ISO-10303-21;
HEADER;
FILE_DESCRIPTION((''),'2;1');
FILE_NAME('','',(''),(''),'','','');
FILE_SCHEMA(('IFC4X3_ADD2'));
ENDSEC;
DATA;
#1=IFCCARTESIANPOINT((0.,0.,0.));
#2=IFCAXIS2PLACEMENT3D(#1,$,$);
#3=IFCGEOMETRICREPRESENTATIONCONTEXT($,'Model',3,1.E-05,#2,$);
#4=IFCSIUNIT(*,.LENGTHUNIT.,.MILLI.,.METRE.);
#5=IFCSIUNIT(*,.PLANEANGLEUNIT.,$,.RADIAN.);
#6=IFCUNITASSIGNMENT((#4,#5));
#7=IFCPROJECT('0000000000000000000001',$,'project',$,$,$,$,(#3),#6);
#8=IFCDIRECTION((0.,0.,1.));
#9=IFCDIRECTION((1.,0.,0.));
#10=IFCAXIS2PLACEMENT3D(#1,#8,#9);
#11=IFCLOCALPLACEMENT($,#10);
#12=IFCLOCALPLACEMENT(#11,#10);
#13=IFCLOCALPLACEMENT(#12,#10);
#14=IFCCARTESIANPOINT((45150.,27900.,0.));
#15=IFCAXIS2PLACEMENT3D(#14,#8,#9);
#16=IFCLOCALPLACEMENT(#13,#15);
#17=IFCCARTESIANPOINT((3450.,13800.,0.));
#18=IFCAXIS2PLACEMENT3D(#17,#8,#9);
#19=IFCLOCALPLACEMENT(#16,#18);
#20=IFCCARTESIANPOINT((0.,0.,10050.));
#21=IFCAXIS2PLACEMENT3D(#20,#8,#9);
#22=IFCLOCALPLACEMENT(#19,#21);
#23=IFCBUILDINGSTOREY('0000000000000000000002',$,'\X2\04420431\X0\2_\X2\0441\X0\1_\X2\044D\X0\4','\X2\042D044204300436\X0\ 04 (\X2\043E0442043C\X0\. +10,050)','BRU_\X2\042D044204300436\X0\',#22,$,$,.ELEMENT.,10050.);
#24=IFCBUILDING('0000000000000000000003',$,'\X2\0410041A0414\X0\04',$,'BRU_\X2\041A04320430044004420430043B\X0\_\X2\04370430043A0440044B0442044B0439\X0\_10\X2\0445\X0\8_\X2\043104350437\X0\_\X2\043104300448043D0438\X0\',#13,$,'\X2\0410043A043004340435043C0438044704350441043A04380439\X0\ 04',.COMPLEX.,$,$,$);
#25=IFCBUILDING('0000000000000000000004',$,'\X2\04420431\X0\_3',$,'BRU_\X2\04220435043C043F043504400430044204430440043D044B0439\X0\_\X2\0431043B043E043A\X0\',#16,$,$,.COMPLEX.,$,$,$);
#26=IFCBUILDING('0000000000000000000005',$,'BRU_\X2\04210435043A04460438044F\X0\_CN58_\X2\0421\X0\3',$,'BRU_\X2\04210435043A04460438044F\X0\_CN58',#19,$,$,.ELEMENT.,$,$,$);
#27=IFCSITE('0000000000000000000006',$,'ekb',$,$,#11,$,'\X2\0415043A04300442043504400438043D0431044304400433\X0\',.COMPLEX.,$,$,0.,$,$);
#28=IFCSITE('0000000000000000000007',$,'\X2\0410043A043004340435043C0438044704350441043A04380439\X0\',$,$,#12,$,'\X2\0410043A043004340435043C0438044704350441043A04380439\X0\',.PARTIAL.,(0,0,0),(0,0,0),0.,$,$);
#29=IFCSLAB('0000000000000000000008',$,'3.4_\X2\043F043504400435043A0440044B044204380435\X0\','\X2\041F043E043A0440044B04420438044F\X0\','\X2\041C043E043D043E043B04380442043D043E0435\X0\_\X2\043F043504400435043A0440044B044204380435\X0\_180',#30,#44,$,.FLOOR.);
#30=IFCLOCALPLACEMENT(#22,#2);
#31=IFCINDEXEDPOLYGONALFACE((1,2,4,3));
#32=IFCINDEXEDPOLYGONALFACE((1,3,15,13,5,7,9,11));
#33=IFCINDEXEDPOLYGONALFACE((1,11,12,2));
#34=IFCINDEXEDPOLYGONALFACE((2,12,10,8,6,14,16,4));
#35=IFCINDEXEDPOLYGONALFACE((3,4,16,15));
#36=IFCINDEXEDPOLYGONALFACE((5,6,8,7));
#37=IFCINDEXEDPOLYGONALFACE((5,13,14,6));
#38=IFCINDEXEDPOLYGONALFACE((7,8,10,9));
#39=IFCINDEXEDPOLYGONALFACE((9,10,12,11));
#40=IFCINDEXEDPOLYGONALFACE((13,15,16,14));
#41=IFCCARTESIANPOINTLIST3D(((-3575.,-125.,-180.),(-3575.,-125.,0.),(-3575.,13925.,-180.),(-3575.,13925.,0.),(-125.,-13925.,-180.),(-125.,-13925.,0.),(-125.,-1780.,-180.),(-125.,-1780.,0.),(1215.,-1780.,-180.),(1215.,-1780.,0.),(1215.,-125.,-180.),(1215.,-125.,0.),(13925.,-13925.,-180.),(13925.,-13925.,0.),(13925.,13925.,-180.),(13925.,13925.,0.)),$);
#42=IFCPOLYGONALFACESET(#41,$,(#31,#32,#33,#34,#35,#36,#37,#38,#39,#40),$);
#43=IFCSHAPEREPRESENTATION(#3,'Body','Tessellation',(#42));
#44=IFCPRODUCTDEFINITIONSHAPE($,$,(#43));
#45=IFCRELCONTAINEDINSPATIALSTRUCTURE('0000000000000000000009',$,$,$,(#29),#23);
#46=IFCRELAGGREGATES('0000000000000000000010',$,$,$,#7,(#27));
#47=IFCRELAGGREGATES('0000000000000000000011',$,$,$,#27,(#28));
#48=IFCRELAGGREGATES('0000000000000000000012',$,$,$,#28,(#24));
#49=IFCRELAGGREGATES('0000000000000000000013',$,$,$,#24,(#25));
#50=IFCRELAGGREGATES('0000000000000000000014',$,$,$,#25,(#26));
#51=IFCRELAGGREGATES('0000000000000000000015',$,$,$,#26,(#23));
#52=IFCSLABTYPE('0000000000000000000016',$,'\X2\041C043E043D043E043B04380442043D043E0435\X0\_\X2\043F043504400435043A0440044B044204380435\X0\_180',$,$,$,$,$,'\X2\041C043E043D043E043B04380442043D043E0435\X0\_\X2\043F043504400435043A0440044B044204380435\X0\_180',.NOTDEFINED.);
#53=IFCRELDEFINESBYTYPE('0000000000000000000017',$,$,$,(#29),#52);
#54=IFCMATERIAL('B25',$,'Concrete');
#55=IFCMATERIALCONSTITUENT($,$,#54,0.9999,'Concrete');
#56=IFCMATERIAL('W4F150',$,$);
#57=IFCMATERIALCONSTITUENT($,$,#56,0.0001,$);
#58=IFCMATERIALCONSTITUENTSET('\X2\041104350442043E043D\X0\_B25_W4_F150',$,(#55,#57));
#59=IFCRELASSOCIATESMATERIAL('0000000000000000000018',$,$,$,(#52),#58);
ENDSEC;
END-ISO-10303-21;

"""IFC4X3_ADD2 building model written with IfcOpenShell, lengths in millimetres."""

from ifc_helpers import new_model, si_unit, frame, origin, origin_with_axes, place, context, project, spatial, polyline, outline, extrude, material, constituent, constituent_set, type_object, element, save


model = new_model("IFC4X3_ADD2")

# Units and contexts
model_context = context("Model", 3, precision=1e-05, world=origin())
ifc_project = project(units=[si_unit("LENGTHUNIT", "METRE", prefix="MILLI"), si_unit("PLANEANGLEUNIT", "RADIAN")], contexts=[model_context])

# Sites, buildings, storey
site_1_placement = place(None, origin_with_axes())
site_1 = spatial("IfcSite", under=ifc_project, at=site_1_placement, Name="ekb", LongName="Екатеринбург", CompositionType="COMPLEX", RefElevation=0.0)
site_2_placement = place(site_1_placement, origin_with_axes())
site_2 = spatial("IfcSite", under=site_1, at=site_2_placement, Name="Академический", LongName="Академический", CompositionType="PARTIAL", RefLatitude=(0, 0, 0), RefLongitude=(0, 0, 0), RefElevation=0.0)
building_1_placement = place(site_2_placement, origin_with_axes())
building_1 = spatial("IfcBuilding", under=site_2, at=building_1_placement, Name="АКД04", ObjectType="BRU_Квартал_закрытый_10х8_без_башни", LongName="Академический 04", CompositionType="COMPLEX")
building_2_placement = place(building_1_placement, frame((45150.0, 27900.0, 0.0), z_axis=(0.0, 0.0, 1.0), x_axis=(1.0, 0.0, 0.0)))
building_2 = spatial("IfcBuilding", under=building_1, at=building_2_placement, Name="тб_3", ObjectType="BRU_Температурный_блок", CompositionType="COMPLEX")
building_3_placement = place(building_2_placement, frame((3450.0, 13800.0, 0.0), z_axis=(0.0, 0.0, 1.0), x_axis=(1.0, 0.0, 0.0)))
building_3 = spatial("IfcBuilding", under=building_2, at=building_3_placement, Name="BRU_Секция_CN58_С3", ObjectType="BRU_Секция_CN58", CompositionType="ELEMENT")
storey_placement = place(building_3_placement, frame((0.0, 0.0, 10050.0), z_axis=(0.0, 0.0, 1.0), x_axis=(1.0, 0.0, 0.0)))
storey = spatial("IfcBuildingStorey", under=building_3, at=storey_placement, Name="тб2_с1_э4", Description="Этаж 04 (отм. +10,050)", ObjectType="BRU_Этаж", CompositionType="ELEMENT", Elevation=10050.0)

# Shared definitions
ifc_material_1 = material(Name="B25", Category="Concrete")
ifc_material_2 = material(Name="W4F150")

# Slab
ifc_constituent_1 = constituent(ifc_material_1, Category="Concrete", fraction=0.9999)
ifc_constituent_2 = constituent(ifc_material_2, fraction=0.0001)
ifc_constituent_set_1 = constituent_set(constituents=[ifc_constituent_1, ifc_constituent_2], Name="Бетон_B25_W4_F150")
slab_type = type_object("IfcSlabType", Name="Монолитное_перекрытие_180", ElementType="Монолитное_перекрытие_180", PredefinedType="NOTDEFINED", material=ifc_constituent_set_1)
slab_placement = place(storey_placement, frame((0.0, 0.0, -180.0), z_axis=(0.0, 0.0, 1.0), x_axis=(1.0, 0.0, 0.0)))
element("IfcSlab", 1, at=slab_placement, inside=storey, type_object=slab_type, Name="3.4_перекрытие", Description="Покрытия", ObjectType="Монолитное_перекрытие_180", PredefinedType="FLOOR", context=model_context, shape_type="SweptSolid", body=[
    extrude(outline(polyline([(-125.0, -13925.0), (13925.0, -13925.0), (13925.0, 13925.0), (-3575.0, 13925.0), (-3575.0, -125.0), (1215.0, -125.0), (1215.0, -1780.0), (-125.0, -1780.0), (-125.0, -13925.0)])), origin_with_axes(), (0.0, 0.0, 1.0), 180.0),
])

save(model, "model.ifc")
